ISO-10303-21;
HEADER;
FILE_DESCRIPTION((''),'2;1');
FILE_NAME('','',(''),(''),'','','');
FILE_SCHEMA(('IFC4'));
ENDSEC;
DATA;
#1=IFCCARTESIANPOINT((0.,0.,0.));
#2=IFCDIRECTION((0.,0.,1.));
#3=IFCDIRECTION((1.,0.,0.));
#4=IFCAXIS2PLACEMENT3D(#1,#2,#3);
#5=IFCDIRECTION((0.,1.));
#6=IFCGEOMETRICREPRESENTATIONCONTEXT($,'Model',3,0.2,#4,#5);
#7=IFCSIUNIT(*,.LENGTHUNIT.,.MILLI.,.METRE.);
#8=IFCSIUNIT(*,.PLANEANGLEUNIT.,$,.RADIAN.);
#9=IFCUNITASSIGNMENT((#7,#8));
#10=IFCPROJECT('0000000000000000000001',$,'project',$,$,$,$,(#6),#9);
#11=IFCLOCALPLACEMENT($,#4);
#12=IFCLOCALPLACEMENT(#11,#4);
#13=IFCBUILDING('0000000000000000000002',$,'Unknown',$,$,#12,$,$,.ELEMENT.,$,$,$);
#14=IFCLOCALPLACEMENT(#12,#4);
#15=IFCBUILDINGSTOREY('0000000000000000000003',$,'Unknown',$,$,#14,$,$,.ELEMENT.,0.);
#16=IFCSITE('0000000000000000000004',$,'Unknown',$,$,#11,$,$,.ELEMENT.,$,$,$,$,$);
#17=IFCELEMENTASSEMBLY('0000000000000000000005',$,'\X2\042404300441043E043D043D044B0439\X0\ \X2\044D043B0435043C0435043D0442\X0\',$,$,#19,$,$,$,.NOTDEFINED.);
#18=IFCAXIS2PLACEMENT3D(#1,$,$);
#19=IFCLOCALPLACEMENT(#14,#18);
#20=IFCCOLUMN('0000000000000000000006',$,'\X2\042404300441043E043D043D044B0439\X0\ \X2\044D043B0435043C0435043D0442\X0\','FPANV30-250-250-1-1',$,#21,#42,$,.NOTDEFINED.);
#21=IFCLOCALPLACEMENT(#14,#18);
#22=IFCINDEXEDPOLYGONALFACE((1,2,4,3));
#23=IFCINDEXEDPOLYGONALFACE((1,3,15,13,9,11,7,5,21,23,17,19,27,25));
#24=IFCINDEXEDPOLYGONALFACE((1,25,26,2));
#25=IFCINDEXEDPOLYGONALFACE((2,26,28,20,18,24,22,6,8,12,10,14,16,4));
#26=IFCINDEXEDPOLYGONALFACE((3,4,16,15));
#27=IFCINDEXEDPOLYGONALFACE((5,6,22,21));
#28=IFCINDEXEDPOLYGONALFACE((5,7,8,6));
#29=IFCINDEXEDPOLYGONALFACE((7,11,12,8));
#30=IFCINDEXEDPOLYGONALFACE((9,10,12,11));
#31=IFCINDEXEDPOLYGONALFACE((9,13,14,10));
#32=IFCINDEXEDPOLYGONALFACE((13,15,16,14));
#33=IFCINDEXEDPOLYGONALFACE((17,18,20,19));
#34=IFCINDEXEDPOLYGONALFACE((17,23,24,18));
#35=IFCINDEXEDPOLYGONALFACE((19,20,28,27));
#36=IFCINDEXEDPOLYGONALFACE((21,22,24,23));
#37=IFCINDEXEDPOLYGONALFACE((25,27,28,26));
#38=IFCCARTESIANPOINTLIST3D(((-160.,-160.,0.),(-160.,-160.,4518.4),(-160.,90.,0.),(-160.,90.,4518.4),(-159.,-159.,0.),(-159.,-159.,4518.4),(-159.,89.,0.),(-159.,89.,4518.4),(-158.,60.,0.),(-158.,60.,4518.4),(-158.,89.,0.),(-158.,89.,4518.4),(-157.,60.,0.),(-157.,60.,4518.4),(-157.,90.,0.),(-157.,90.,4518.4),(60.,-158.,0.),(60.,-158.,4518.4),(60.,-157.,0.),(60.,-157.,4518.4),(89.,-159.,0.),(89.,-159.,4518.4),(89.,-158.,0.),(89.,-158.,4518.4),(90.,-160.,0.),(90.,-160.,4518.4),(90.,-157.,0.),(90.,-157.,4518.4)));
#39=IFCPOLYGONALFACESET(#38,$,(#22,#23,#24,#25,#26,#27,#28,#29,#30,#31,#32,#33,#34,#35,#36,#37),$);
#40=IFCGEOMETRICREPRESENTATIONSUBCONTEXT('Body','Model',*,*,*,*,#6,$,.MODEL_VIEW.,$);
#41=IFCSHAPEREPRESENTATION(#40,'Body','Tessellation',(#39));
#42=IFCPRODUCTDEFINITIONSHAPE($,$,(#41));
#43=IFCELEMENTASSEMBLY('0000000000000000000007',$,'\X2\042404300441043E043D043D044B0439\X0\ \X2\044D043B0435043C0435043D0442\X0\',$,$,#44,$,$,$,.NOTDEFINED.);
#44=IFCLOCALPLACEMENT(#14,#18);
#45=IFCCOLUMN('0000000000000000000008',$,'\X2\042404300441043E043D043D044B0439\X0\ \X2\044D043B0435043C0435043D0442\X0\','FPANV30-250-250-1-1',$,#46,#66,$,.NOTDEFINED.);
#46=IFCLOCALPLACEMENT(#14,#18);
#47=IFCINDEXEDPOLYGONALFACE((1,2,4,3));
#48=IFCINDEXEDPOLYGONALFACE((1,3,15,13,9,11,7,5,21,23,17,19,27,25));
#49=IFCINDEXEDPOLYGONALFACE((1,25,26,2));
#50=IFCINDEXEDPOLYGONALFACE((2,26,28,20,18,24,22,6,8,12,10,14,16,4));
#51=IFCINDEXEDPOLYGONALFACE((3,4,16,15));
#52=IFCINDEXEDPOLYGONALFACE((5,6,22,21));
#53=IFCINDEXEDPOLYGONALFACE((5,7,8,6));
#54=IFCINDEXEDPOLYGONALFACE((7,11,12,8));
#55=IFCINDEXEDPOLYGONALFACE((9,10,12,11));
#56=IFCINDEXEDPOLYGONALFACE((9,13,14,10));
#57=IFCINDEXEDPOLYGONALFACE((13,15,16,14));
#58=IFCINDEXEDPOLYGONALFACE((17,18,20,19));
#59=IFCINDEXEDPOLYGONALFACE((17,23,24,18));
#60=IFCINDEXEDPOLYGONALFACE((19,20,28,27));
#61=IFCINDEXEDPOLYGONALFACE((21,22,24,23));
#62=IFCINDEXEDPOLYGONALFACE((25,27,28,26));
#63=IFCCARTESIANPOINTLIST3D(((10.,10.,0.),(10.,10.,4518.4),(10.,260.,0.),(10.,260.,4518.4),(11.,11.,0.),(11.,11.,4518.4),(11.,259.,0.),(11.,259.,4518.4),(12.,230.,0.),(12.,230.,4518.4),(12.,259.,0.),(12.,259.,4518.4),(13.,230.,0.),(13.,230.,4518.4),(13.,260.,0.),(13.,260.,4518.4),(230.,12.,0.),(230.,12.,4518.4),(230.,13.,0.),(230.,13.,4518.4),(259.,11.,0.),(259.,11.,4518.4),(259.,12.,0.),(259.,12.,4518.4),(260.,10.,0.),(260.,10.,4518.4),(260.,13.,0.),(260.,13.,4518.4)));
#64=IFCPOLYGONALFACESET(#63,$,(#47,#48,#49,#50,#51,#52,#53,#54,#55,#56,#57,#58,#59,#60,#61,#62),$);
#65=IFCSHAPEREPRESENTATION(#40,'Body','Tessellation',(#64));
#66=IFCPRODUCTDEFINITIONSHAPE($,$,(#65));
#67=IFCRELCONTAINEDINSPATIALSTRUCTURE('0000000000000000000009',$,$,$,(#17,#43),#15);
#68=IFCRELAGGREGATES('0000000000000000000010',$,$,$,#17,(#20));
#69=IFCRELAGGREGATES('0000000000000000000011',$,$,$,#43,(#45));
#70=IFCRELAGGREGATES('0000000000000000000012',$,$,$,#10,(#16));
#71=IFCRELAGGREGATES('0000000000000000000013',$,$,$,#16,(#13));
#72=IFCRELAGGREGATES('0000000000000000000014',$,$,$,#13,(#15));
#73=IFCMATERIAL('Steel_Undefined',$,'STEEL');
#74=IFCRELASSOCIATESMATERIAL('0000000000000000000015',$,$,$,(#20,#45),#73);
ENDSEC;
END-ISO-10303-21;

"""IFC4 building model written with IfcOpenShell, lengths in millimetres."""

from ifc_helpers import new_model, si_unit, direction, frame, origin_with_axes, place, context, subcontext, project, spatial, line, indexed_curve, outline, extrude, material, element, aggregate, save


model = new_model("IFC4")

# Units and contexts
model_context = context("Model", 3, precision=0.2, world=origin_with_axes(), true_north=direction((0.0, 1.0)))
body_context = subcontext(model_context, "Body", "Model", "MODEL_VIEW")
ifc_project = project(units=[si_unit("LENGTHUNIT", "METRE", prefix="MILLI"), si_unit("PLANEANGLEUNIT", "RADIAN")], contexts=[model_context])

# Site, building, storey
site_placement = place(None, origin_with_axes())
site = spatial("IfcSite", under=ifc_project, at=site_placement, Name="Unknown", CompositionType="ELEMENT")
building_placement = place(site_placement, origin_with_axes())
building = spatial("IfcBuilding", under=site, at=building_placement, Name="Unknown", CompositionType="ELEMENT")
storey_placement = place(building_placement, origin_with_axes())
storey = spatial("IfcBuildingStorey", under=building, at=storey_placement, Name="Unknown", CompositionType="ELEMENT", Elevation=0.0)

# Element assemblies, columns
assembly_1_placement = place(storey_placement, frame((-160.0, -160.0, 0.0), z_axis=(0.0, 1.0, 0.0), x_axis=(0.0, 0.0, 1.0)))
assembly_1 = element("IfcElementAssembly", 1, at=assembly_1_placement, inside=storey, Name="Фасонный элемент", PredefinedType="NOTDEFINED")
ifc_material_1 = material(Name="Steel_Undefined", Category="STEEL")
column_1_placement = place(assembly_1_placement, origin_with_axes())
column_1 = element("IfcColumn", 2, at=column_1_placement, material=ifc_material_1, Name="Фасонный элемент", Description="FPANV30-250-250-1-1", PredefinedType="NOTDEFINED", context=body_context, shape_type="SolidModel", body=[
    extrude(outline(indexed_curve([(0.0, 0.0), (250.0, 0.0), (250.0, 3.0), (220.0, 3.0), (220.0, 2.0), (249.0, 2.0), (249.0, 1.0), (1.0, 1.0), (1.0, 249.0), (2.0, 249.0), (2.0, 220.0), (3.0, 220.0), (3.0, 250.0), (0.0, 250.0)], segments=[line(1, 2, 3, 4, 5, 6, 7, 8, 9, 10, 11, 12, 13, 14, 1)])), frame((0.0, 0.0, 0.0), z_axis=(-1.0, 0.0, 0.0), x_axis=(0.0, 0.0, 1.0)), (0.0, 0.0, -1.0), 4518.4),
])
aggregate(assembly_1, [column_1])
assembly_2_placement = place(storey_placement, frame((10.0, 10.0, 0.0), z_axis=(0.0, 1.0, 0.0), x_axis=(0.0, 0.0, 1.0)))
assembly_2 = element("IfcElementAssembly", 3, at=assembly_2_placement, inside=storey, Name="Фасонный элемент", PredefinedType="NOTDEFINED")
column_2_placement = place(assembly_2_placement, origin_with_axes())
column_2 = element("IfcColumn", 4, at=column_2_placement, material=ifc_material_1, Name="Фасонный элемент", Description="FPANV30-250-250-1-1", PredefinedType="NOTDEFINED", context=body_context, shape_type="SolidModel", body=[
    extrude(outline(indexed_curve([(0.0, 0.0), (250.0, 0.0), (250.0, 3.0), (220.0, 3.0), (220.0, 2.0), (249.0, 2.0), (249.0, 1.0), (1.0, 1.0), (1.0, 249.0), (2.0, 249.0), (2.0, 220.0), (3.0, 220.0), (3.0, 250.0), (0.0, 250.0)], segments=[line(1, 2, 3, 4, 5, 6, 7, 8, 9, 10, 11, 12, 13, 14, 1)])), frame((0.0, 0.0, 0.0), z_axis=(-1.0, 0.0, 0.0), x_axis=(0.0, 0.0, 1.0)), (0.0, 0.0, -1.0), 4518.4),
])
aggregate(assembly_2, [column_2])

save(model, "model.ifc")
